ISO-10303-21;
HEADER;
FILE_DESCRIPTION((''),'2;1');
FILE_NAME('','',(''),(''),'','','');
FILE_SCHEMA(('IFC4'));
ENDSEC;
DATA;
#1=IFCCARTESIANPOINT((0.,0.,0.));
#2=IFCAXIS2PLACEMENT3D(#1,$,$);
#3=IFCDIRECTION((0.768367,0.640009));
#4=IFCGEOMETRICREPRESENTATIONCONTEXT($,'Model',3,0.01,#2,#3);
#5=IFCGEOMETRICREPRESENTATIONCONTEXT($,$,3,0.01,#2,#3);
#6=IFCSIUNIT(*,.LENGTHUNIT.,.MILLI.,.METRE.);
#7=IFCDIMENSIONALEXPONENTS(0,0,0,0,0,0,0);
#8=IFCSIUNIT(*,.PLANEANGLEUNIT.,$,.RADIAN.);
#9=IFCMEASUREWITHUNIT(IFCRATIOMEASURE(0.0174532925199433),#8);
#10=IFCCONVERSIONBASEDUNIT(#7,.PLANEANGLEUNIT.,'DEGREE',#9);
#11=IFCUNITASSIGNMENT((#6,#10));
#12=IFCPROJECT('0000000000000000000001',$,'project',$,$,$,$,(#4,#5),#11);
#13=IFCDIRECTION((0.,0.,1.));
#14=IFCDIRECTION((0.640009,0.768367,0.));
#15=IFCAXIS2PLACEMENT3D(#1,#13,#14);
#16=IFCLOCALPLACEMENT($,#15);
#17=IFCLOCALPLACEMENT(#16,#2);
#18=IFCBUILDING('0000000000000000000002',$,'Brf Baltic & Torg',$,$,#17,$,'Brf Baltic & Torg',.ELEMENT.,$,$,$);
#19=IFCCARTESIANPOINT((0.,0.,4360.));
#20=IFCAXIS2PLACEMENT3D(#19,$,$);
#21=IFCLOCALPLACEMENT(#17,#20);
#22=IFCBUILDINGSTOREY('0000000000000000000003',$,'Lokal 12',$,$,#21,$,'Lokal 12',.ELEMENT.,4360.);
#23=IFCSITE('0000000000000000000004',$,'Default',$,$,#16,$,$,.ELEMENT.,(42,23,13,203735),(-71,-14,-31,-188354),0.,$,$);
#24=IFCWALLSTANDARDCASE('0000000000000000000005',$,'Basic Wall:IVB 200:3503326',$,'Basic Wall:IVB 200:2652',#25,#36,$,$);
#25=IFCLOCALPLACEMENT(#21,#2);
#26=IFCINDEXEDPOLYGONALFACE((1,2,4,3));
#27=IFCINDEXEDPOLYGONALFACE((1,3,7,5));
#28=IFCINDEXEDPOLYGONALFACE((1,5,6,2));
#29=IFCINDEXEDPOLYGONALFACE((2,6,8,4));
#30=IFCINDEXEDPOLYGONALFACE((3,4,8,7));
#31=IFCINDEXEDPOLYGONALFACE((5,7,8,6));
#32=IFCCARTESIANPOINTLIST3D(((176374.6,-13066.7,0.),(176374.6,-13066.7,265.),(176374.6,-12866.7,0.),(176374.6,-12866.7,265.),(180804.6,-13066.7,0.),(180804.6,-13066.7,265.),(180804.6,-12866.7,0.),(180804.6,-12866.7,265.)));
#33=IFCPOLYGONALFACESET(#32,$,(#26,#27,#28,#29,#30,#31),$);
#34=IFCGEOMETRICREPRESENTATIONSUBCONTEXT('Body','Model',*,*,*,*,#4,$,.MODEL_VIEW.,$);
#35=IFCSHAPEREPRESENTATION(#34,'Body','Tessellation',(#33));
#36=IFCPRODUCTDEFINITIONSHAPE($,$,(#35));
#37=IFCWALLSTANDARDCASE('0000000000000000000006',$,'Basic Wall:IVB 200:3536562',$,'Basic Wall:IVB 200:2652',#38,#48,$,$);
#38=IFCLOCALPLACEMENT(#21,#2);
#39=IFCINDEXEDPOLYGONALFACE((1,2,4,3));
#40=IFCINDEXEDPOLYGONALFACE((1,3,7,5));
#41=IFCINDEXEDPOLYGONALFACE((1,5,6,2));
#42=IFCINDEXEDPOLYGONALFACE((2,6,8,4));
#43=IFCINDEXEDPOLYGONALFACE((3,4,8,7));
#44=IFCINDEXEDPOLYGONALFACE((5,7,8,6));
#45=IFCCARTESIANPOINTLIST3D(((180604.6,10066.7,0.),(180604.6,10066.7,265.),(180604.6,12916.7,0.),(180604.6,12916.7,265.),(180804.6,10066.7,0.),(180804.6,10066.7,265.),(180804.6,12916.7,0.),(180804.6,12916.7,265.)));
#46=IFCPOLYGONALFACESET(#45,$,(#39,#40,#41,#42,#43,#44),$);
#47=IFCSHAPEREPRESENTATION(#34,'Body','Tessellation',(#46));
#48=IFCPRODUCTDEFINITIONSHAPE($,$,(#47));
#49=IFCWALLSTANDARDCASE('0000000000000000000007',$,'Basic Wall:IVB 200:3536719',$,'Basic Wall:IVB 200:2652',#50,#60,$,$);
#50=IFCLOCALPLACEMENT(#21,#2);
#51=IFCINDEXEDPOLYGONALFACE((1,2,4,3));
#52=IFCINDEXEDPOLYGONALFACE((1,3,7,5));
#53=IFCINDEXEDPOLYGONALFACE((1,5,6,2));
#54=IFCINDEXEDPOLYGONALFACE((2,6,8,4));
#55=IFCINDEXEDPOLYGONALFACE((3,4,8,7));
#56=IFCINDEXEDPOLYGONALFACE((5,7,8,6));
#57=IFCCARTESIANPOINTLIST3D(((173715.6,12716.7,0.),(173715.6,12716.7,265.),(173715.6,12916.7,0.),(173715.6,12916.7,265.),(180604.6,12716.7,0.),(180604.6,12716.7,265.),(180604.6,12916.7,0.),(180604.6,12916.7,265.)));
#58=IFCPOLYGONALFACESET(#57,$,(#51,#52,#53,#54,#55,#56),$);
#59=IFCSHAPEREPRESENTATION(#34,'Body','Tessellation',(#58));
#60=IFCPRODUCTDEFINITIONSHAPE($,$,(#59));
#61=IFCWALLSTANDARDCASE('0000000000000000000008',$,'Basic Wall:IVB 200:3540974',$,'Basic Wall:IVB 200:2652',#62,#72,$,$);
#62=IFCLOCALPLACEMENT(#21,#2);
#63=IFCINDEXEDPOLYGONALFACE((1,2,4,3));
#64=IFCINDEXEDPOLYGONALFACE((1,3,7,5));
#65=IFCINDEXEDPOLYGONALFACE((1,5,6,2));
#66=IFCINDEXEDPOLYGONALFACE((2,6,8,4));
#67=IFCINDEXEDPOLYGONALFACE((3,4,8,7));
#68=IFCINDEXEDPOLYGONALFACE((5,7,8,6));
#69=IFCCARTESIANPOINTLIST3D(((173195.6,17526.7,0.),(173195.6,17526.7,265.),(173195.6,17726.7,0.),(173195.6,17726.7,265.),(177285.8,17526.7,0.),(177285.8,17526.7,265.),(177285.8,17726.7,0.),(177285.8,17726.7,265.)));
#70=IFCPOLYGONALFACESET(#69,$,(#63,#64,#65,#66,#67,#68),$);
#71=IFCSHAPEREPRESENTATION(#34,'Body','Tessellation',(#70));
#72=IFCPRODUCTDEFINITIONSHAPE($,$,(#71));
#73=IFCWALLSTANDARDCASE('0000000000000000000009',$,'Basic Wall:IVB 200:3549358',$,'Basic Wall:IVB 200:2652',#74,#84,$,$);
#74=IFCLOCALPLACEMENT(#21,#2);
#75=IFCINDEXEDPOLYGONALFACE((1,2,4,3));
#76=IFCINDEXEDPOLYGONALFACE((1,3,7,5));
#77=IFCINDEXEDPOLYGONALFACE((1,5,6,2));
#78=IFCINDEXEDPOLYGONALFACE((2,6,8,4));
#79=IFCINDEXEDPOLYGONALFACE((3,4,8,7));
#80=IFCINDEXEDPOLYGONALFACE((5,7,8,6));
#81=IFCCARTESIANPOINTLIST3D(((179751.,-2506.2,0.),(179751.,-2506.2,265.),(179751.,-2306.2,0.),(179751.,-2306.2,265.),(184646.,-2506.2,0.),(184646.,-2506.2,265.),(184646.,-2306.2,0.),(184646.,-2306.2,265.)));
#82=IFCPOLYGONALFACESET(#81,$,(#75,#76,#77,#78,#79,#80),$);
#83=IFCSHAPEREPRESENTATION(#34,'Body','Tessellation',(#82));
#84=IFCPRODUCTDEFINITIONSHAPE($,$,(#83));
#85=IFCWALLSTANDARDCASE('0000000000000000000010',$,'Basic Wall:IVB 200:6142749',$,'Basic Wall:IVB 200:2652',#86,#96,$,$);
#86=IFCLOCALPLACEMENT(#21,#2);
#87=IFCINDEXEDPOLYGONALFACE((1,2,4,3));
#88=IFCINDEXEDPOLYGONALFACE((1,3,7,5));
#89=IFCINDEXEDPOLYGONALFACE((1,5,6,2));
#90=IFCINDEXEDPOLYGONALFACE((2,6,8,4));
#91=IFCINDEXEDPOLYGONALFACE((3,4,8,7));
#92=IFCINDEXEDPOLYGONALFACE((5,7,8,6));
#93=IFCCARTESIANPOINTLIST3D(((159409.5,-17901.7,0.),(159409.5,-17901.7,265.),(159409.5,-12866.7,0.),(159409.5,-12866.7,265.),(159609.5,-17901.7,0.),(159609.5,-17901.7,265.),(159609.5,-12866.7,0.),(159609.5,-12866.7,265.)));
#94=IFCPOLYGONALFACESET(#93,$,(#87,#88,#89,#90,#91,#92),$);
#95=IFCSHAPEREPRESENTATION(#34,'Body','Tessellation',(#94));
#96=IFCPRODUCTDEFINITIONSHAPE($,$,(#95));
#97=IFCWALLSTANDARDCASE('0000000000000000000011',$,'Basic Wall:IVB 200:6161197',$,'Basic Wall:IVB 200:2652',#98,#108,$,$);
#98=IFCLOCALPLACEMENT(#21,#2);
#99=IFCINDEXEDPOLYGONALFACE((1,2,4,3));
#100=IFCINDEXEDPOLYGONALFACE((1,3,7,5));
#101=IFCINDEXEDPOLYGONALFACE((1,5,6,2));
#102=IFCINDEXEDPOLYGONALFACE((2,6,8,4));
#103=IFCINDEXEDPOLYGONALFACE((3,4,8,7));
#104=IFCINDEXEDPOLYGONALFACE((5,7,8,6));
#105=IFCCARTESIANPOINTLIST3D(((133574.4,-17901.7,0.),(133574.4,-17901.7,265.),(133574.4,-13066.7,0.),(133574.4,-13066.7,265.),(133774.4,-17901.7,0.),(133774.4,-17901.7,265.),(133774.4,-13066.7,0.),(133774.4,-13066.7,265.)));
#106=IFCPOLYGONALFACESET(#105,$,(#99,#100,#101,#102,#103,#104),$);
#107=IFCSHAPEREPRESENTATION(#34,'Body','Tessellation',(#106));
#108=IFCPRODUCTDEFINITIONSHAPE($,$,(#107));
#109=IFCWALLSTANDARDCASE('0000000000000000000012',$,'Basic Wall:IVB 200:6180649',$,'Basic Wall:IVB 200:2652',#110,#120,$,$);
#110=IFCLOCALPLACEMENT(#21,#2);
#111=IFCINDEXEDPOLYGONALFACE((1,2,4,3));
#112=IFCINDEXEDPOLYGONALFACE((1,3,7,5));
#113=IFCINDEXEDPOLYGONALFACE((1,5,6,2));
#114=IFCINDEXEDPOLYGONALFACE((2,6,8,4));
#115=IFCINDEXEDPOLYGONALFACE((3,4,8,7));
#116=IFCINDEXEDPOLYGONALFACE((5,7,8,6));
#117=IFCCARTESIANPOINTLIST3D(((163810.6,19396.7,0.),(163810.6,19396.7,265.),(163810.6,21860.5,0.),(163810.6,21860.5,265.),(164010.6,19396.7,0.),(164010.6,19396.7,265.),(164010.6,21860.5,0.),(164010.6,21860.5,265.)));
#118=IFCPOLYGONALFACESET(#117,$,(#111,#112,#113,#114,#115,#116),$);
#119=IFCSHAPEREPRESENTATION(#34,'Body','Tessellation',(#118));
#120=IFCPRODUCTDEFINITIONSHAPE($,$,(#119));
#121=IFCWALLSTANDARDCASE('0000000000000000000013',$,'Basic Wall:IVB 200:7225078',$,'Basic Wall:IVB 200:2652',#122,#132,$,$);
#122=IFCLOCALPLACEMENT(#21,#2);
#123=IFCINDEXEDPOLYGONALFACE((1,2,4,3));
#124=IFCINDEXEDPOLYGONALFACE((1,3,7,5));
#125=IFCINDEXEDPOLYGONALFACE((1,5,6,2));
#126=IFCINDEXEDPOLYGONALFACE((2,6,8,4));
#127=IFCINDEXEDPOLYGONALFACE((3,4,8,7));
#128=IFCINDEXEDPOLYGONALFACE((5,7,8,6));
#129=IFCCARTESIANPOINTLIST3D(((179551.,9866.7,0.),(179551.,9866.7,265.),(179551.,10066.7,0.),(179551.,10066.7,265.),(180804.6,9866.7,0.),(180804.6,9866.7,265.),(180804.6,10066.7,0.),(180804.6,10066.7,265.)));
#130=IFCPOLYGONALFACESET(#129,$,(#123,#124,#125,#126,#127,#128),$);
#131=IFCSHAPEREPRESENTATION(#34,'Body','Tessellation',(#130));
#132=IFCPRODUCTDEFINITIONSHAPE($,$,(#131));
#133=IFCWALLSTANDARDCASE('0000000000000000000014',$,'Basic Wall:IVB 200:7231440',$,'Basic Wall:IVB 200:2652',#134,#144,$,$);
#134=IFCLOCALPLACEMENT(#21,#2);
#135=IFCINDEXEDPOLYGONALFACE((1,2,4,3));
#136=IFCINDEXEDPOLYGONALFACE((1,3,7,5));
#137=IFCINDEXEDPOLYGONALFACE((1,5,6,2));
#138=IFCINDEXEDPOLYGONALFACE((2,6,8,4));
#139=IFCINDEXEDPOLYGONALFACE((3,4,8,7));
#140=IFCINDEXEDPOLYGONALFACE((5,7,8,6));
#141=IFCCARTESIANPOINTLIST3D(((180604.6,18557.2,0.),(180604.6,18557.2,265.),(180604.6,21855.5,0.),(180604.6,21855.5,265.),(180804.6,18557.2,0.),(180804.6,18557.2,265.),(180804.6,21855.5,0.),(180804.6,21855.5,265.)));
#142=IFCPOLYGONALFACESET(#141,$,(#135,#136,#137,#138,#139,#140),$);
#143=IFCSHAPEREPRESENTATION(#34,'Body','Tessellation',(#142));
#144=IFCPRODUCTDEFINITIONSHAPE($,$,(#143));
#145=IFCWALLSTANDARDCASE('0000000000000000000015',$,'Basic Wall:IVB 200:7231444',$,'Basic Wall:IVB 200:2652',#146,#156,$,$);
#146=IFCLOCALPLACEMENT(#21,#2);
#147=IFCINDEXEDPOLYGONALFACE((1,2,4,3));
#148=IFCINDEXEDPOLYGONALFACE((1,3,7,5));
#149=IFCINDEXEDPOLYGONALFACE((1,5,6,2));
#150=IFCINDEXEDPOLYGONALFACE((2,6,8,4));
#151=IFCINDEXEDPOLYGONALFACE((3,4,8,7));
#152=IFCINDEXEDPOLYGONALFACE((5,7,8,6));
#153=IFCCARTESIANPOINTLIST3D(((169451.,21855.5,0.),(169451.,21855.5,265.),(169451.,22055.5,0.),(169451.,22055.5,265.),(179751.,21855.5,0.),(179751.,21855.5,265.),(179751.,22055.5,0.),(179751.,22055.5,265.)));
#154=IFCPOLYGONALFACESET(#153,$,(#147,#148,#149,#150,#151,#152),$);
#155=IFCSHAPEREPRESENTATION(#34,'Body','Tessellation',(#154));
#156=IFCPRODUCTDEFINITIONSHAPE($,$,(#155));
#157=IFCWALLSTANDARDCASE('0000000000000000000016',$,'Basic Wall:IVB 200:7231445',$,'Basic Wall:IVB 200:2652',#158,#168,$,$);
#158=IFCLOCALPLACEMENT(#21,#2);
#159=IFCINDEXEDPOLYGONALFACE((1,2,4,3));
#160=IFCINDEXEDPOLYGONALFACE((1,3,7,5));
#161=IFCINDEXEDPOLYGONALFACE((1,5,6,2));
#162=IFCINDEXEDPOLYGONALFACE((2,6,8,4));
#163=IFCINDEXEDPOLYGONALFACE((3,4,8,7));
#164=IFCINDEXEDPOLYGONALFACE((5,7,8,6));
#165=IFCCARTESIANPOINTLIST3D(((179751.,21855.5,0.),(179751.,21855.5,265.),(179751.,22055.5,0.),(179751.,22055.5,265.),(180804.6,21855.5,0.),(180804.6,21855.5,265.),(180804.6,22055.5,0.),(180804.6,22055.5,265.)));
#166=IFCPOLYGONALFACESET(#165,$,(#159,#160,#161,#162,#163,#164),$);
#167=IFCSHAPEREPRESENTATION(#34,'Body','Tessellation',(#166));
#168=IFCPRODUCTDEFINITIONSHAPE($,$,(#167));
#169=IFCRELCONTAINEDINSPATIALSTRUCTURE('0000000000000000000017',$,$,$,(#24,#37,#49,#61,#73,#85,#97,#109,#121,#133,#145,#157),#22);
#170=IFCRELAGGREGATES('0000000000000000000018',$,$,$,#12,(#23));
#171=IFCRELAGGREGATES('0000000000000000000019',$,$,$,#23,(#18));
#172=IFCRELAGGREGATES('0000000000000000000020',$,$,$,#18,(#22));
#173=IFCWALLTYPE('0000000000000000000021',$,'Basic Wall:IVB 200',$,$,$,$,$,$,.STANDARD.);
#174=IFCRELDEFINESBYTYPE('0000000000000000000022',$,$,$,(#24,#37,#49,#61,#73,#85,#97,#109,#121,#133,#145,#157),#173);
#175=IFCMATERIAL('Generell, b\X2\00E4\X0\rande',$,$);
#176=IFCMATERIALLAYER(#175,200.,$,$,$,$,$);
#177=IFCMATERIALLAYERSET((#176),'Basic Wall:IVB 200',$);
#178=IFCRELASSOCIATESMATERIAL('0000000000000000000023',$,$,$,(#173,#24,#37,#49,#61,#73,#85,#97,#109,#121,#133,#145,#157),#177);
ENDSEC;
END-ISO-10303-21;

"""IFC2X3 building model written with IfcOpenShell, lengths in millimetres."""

from ifc_helpers import new_model, entity, si_unit, converted_unit, direction, frame, frame_2d, origin, place, context, subcontext, project, spatial, rectangle, extrude, clip, halfspace, material, layer, layer_set, layer_usage, type_object, element, save


model = new_model("IFC2X3")

# Units and contexts
model_context = context("Model", 3, precision=0.01, world=origin(), true_north=direction((0.768367, 0.640009)))
context_of_model = context(None, 3, precision=0.01, world=origin(), true_north=direction((0.768367, 0.640009)))
body_context = subcontext(model_context, "Body", "Model", "MODEL_VIEW")
ifc_project = project(units=[si_unit("LENGTHUNIT", "METRE", prefix="MILLI"), converted_unit("PLANEANGLEUNIT", "DEGREE", entity("IfcRatioMeasure", 0.0174532925199433), si_unit("PLANEANGLEUNIT", "RADIAN"), dimensions=[0, 0, 0, 0, 0, 0, 0])], contexts=[model_context, context_of_model])

# Site, building, storey
site_placement = place(None, frame((0.0, 0.0, 0.0), z_axis=(0.0, 0.0, 1.0), x_axis=(0.640009, 0.768367, 0.0)))
site = spatial("IfcSite", under=ifc_project, at=site_placement, Name="Default", CompositionType="ELEMENT", RefLatitude=(42, 23, 13, 203735), RefLongitude=(-71, -14, -31, -188354), RefElevation=0.0)
building_placement = place(site_placement, origin())
building = spatial("IfcBuilding", under=site, at=building_placement, Name="Brf Baltic & Torg", LongName="Brf Baltic & Torg", CompositionType="ELEMENT")
storey_placement = place(building_placement, frame((0.0, 0.0, 4360.0)))
storey = spatial("IfcBuildingStorey", under=building, at=storey_placement, Name="Lokal 12", LongName="Lokal 12", CompositionType="ELEMENT", Elevation=4360.0)

# Shared definitions
ifc_material_1 = material(Name="Generell, bärande")
ifc_layer_1 = layer(ifc_material_1, 200.0)
ifc_layer_set_1 = layer_set([ifc_layer_1], Name="Basic Wall:IVB 200")
wall_type_1 = type_object("IfcWallType", Name="Basic Wall:IVB 200", PredefinedType="STANDARD", material=ifc_layer_set_1)

# Walls
ifc_layer_usage_1 = layer_usage(ifc_layer_set_1, "AXIS2", "NEGATIVE", 100.0)
wall_1_placement = place(storey_placement, frame((180804.6, -12966.7, 0.0), z_axis=(0.0, 0.0, 1.0), x_axis=(-1.0, 0.0, 0.0)))
element("IfcWallStandardCase", 1, at=wall_1_placement, inside=storey, type_object=wall_type_1, material=ifc_layer_usage_1, Name="Basic Wall:IVB 200:3503326", ObjectType="Basic Wall:IVB 200:2652", context=body_context, shape_type="Clipping", body=[
    clip(extrude(rectangle(XDim=4430.0, YDim=200.0, at=frame_2d((2215.0, 0.0), x_axis=(-1.0, 0.0))), origin(), (0.0, 0.0, 1.0), 265.0), halfspace(frame((0.0, 0.0, -2710.0)), True)),
])
ifc_layer_usage_2 = layer_usage(ifc_layer_set_1, "AXIS2", "POSITIVE", -100.0)
wall_2_placement = place(storey_placement, frame((180704.6, 10066.7, 0.0), z_axis=(0.0, 0.0, 1.0), x_axis=(0.0, 1.0, 0.0)))
element("IfcWallStandardCase", 2, at=wall_2_placement, inside=storey, type_object=wall_type_1, material=ifc_layer_usage_2, Name="Basic Wall:IVB 200:3536562", ObjectType="Basic Wall:IVB 200:2652", context=body_context, shape_type="Clipping", body=[
    clip(extrude(rectangle(XDim=2850.0, YDim=200.0, at=frame_2d((1425.0, 0.0), x_axis=(-1.0, 0.0))), origin(), (0.0, 0.0, 1.0), 265.0), halfspace(frame((0.0, 0.0, -2710.0)), True)),
])
ifc_layer_usage_3 = layer_usage(ifc_layer_set_1, "AXIS2", "NEGATIVE", 100.0)
wall_3_placement = place(storey_placement, frame((173715.6, 12816.7, 0.0)))
element("IfcWallStandardCase", 3, at=wall_3_placement, inside=storey, type_object=wall_type_1, material=ifc_layer_usage_3, Name="Basic Wall:IVB 200:3536719", ObjectType="Basic Wall:IVB 200:2652", context=body_context, shape_type="Clipping", body=[
    clip(extrude(rectangle(XDim=6889.0, YDim=200.0, at=frame_2d((3444.5, 0.0), x_axis=(-1.0, 0.0))), origin(), (0.0, 0.0, 1.0), 265.0), halfspace(frame((0.0, 0.0, -2710.0)), True)),
])
ifc_layer_usage_4 = layer_usage(ifc_layer_set_1, "AXIS2", "NEGATIVE", 100.0)
wall_4_placement = place(storey_placement, frame((173195.6, 17626.7, 0.0)))
element("IfcWallStandardCase", 4, at=wall_4_placement, inside=storey, type_object=wall_type_1, material=ifc_layer_usage_4, Name="Basic Wall:IVB 200:3540974", ObjectType="Basic Wall:IVB 200:2652", context=body_context, shape_type="Clipping", body=[
    clip(extrude(rectangle(XDim=4090.2, YDim=200.0, at=frame_2d((2045.1, 0.0), x_axis=(-1.0, 0.0))), origin(), (0.0, 0.0, 1.0), 265.0), halfspace(frame((0.0, 0.0, -2710.0)), True)),
])
ifc_layer_usage_5 = layer_usage(ifc_layer_set_1, "AXIS2", "NEGATIVE", 100.0)
wall_5_placement = place(storey_placement, frame((179751.0, -2406.2, 0.0)))
element("IfcWallStandardCase", 5, at=wall_5_placement, inside=storey, type_object=wall_type_1, material=ifc_layer_usage_5, Name="Basic Wall:IVB 200:3549358", ObjectType="Basic Wall:IVB 200:2652", context=body_context, shape_type="Clipping", body=[
    clip(extrude(rectangle(XDim=4895.0, YDim=200.0, at=frame_2d((2447.5, 0.0), x_axis=(-1.0, 0.0))), origin(), (0.0, 0.0, 1.0), 265.0), halfspace(frame((0.0, 0.0, -2710.0)), True)),
])
ifc_layer_usage_6 = layer_usage(ifc_layer_set_1, "AXIS2", "POSITIVE", -100.0)
wall_6_placement = place(storey_placement, frame((159509.5, -12866.7, 0.0), z_axis=(0.0, 0.0, 1.0), x_axis=(0.0, -1.0, 0.0)))
element("IfcWallStandardCase", 6, at=wall_6_placement, inside=storey, type_object=wall_type_1, material=ifc_layer_usage_6, Name="Basic Wall:IVB 200:6142749", ObjectType="Basic Wall:IVB 200:2652", context=body_context, shape_type="Clipping", body=[
    clip(extrude(rectangle(XDim=5035.0, YDim=200.0, at=frame_2d((2517.5, 0.0), x_axis=(-1.0, 0.0))), origin(), (0.0, 0.0, 1.0), 265.0), halfspace(frame((0.0, 0.0, -2710.0)), True)),
])
ifc_layer_usage_7 = layer_usage(ifc_layer_set_1, "AXIS2", "NEGATIVE", 100.0)
wall_7_placement = place(storey_placement, frame((133674.4, -17901.7, 0.0), z_axis=(0.0, 0.0, 1.0), x_axis=(0.0, 1.0, 0.0)))
element("IfcWallStandardCase", 7, at=wall_7_placement, inside=storey, type_object=wall_type_1, material=ifc_layer_usage_7, Name="Basic Wall:IVB 200:6161197", ObjectType="Basic Wall:IVB 200:2652", context=body_context, shape_type="Clipping", body=[
    clip(extrude(rectangle(XDim=4835.0, YDim=200.0, at=frame_2d((2417.5, 0.0), x_axis=(-1.0, 0.0))), origin(), (0.0, 0.0, 1.0), 265.0), halfspace(frame((0.0, 0.0, -2710.0)), True)),
])
ifc_layer_usage_8 = layer_usage(ifc_layer_set_1, "AXIS2", "NEGATIVE", 100.0)
wall_8_placement = place(storey_placement, frame((163910.6, 19396.7, 0.0), z_axis=(0.0, 0.0, 1.0), x_axis=(0.0, 1.0, 0.0)))
element("IfcWallStandardCase", 8, at=wall_8_placement, inside=storey, type_object=wall_type_1, material=ifc_layer_usage_8, Name="Basic Wall:IVB 200:6180649", ObjectType="Basic Wall:IVB 200:2652", context=body_context, shape_type="Clipping", body=[
    clip(extrude(rectangle(XDim=2463.7, YDim=200.0, at=frame_2d((1231.9, 0.0), x_axis=(-1.0, 0.0))), origin(), (0.0, 0.0, 1.0), 265.0), halfspace(frame((0.0, 0.0, -2710.0)), True)),
])
ifc_layer_usage_9 = layer_usage(ifc_layer_set_1, "AXIS2", "NEGATIVE", 100.0)
wall_9_placement = place(storey_placement, frame((180804.6, 9966.7, 0.0), z_axis=(0.0, 0.0, 1.0), x_axis=(-1.0, 0.0, 0.0)))
element("IfcWallStandardCase", 9, at=wall_9_placement, inside=storey, type_object=wall_type_1, material=ifc_layer_usage_9, Name="Basic Wall:IVB 200:7225078", ObjectType="Basic Wall:IVB 200:2652", context=body_context, shape_type="Clipping", body=[
    clip(extrude(rectangle(XDim=1253.6, YDim=200.0, at=frame_2d((626.8, 0.0), x_axis=(-1.0, 0.0))), origin(), (0.0, 0.0, 1.0), 265.0), halfspace(frame((0.0, 0.0, -2710.0)), True)),
])
ifc_layer_usage_10 = layer_usage(ifc_layer_set_1, "AXIS2", "POSITIVE", -100.0)
wall_10_placement = place(storey_placement, frame((180704.6, 18557.2, 0.0), z_axis=(0.0, 0.0, 1.0), x_axis=(0.0, 1.0, 0.0)))
element("IfcWallStandardCase", 10, at=wall_10_placement, inside=storey, type_object=wall_type_1, material=ifc_layer_usage_10, Name="Basic Wall:IVB 200:7231440", ObjectType="Basic Wall:IVB 200:2652", context=body_context, shape_type="Clipping", body=[
    clip(extrude(rectangle(XDim=3298.3, YDim=200.0, at=frame_2d((1649.1, 0.0), x_axis=(-1.0, 0.0))), origin(), (0.0, 0.0, 1.0), 265.0), halfspace(frame((0.0, 0.0, -2710.0)), True)),
])
ifc_layer_usage_11 = layer_usage(ifc_layer_set_1, "AXIS2", "NEGATIVE", 100.0)
wall_11_placement = place(storey_placement, frame((169451.0, 21955.5, 0.0)))
element("IfcWallStandardCase", 11, at=wall_11_placement, inside=storey, type_object=wall_type_1, material=ifc_layer_usage_11, Name="Basic Wall:IVB 200:7231444", ObjectType="Basic Wall:IVB 200:2652", context=body_context, shape_type="Clipping", body=[
    clip(extrude(rectangle(XDim=10300.0, YDim=200.0, at=frame_2d((5150.0, 0.0), x_axis=(-1.0, 0.0))), origin(), (0.0, 0.0, 1.0), 265.0), halfspace(frame((0.0, 0.0, -2710.0)), True)),
])
ifc_layer_usage_12 = layer_usage(ifc_layer_set_1, "AXIS2", "NEGATIVE", 100.0)
wall_12_placement = place(storey_placement, frame((179751.0, 21955.5, 0.0)))
element("IfcWallStandardCase", 12, at=wall_12_placement, inside=storey, type_object=wall_type_1, material=ifc_layer_usage_12, Name="Basic Wall:IVB 200:7231445", ObjectType="Basic Wall:IVB 200:2652", context=body_context, shape_type="Clipping", body=[
    clip(extrude(rectangle(XDim=1053.6, YDim=200.0, at=frame_2d((526.8, 0.0), x_axis=(-1.0, 0.0))), origin(), (0.0, 0.0, 1.0), 265.0), halfspace(frame((0.0, 0.0, -2710.0)), True)),
])

save(model, "model.ifc")
